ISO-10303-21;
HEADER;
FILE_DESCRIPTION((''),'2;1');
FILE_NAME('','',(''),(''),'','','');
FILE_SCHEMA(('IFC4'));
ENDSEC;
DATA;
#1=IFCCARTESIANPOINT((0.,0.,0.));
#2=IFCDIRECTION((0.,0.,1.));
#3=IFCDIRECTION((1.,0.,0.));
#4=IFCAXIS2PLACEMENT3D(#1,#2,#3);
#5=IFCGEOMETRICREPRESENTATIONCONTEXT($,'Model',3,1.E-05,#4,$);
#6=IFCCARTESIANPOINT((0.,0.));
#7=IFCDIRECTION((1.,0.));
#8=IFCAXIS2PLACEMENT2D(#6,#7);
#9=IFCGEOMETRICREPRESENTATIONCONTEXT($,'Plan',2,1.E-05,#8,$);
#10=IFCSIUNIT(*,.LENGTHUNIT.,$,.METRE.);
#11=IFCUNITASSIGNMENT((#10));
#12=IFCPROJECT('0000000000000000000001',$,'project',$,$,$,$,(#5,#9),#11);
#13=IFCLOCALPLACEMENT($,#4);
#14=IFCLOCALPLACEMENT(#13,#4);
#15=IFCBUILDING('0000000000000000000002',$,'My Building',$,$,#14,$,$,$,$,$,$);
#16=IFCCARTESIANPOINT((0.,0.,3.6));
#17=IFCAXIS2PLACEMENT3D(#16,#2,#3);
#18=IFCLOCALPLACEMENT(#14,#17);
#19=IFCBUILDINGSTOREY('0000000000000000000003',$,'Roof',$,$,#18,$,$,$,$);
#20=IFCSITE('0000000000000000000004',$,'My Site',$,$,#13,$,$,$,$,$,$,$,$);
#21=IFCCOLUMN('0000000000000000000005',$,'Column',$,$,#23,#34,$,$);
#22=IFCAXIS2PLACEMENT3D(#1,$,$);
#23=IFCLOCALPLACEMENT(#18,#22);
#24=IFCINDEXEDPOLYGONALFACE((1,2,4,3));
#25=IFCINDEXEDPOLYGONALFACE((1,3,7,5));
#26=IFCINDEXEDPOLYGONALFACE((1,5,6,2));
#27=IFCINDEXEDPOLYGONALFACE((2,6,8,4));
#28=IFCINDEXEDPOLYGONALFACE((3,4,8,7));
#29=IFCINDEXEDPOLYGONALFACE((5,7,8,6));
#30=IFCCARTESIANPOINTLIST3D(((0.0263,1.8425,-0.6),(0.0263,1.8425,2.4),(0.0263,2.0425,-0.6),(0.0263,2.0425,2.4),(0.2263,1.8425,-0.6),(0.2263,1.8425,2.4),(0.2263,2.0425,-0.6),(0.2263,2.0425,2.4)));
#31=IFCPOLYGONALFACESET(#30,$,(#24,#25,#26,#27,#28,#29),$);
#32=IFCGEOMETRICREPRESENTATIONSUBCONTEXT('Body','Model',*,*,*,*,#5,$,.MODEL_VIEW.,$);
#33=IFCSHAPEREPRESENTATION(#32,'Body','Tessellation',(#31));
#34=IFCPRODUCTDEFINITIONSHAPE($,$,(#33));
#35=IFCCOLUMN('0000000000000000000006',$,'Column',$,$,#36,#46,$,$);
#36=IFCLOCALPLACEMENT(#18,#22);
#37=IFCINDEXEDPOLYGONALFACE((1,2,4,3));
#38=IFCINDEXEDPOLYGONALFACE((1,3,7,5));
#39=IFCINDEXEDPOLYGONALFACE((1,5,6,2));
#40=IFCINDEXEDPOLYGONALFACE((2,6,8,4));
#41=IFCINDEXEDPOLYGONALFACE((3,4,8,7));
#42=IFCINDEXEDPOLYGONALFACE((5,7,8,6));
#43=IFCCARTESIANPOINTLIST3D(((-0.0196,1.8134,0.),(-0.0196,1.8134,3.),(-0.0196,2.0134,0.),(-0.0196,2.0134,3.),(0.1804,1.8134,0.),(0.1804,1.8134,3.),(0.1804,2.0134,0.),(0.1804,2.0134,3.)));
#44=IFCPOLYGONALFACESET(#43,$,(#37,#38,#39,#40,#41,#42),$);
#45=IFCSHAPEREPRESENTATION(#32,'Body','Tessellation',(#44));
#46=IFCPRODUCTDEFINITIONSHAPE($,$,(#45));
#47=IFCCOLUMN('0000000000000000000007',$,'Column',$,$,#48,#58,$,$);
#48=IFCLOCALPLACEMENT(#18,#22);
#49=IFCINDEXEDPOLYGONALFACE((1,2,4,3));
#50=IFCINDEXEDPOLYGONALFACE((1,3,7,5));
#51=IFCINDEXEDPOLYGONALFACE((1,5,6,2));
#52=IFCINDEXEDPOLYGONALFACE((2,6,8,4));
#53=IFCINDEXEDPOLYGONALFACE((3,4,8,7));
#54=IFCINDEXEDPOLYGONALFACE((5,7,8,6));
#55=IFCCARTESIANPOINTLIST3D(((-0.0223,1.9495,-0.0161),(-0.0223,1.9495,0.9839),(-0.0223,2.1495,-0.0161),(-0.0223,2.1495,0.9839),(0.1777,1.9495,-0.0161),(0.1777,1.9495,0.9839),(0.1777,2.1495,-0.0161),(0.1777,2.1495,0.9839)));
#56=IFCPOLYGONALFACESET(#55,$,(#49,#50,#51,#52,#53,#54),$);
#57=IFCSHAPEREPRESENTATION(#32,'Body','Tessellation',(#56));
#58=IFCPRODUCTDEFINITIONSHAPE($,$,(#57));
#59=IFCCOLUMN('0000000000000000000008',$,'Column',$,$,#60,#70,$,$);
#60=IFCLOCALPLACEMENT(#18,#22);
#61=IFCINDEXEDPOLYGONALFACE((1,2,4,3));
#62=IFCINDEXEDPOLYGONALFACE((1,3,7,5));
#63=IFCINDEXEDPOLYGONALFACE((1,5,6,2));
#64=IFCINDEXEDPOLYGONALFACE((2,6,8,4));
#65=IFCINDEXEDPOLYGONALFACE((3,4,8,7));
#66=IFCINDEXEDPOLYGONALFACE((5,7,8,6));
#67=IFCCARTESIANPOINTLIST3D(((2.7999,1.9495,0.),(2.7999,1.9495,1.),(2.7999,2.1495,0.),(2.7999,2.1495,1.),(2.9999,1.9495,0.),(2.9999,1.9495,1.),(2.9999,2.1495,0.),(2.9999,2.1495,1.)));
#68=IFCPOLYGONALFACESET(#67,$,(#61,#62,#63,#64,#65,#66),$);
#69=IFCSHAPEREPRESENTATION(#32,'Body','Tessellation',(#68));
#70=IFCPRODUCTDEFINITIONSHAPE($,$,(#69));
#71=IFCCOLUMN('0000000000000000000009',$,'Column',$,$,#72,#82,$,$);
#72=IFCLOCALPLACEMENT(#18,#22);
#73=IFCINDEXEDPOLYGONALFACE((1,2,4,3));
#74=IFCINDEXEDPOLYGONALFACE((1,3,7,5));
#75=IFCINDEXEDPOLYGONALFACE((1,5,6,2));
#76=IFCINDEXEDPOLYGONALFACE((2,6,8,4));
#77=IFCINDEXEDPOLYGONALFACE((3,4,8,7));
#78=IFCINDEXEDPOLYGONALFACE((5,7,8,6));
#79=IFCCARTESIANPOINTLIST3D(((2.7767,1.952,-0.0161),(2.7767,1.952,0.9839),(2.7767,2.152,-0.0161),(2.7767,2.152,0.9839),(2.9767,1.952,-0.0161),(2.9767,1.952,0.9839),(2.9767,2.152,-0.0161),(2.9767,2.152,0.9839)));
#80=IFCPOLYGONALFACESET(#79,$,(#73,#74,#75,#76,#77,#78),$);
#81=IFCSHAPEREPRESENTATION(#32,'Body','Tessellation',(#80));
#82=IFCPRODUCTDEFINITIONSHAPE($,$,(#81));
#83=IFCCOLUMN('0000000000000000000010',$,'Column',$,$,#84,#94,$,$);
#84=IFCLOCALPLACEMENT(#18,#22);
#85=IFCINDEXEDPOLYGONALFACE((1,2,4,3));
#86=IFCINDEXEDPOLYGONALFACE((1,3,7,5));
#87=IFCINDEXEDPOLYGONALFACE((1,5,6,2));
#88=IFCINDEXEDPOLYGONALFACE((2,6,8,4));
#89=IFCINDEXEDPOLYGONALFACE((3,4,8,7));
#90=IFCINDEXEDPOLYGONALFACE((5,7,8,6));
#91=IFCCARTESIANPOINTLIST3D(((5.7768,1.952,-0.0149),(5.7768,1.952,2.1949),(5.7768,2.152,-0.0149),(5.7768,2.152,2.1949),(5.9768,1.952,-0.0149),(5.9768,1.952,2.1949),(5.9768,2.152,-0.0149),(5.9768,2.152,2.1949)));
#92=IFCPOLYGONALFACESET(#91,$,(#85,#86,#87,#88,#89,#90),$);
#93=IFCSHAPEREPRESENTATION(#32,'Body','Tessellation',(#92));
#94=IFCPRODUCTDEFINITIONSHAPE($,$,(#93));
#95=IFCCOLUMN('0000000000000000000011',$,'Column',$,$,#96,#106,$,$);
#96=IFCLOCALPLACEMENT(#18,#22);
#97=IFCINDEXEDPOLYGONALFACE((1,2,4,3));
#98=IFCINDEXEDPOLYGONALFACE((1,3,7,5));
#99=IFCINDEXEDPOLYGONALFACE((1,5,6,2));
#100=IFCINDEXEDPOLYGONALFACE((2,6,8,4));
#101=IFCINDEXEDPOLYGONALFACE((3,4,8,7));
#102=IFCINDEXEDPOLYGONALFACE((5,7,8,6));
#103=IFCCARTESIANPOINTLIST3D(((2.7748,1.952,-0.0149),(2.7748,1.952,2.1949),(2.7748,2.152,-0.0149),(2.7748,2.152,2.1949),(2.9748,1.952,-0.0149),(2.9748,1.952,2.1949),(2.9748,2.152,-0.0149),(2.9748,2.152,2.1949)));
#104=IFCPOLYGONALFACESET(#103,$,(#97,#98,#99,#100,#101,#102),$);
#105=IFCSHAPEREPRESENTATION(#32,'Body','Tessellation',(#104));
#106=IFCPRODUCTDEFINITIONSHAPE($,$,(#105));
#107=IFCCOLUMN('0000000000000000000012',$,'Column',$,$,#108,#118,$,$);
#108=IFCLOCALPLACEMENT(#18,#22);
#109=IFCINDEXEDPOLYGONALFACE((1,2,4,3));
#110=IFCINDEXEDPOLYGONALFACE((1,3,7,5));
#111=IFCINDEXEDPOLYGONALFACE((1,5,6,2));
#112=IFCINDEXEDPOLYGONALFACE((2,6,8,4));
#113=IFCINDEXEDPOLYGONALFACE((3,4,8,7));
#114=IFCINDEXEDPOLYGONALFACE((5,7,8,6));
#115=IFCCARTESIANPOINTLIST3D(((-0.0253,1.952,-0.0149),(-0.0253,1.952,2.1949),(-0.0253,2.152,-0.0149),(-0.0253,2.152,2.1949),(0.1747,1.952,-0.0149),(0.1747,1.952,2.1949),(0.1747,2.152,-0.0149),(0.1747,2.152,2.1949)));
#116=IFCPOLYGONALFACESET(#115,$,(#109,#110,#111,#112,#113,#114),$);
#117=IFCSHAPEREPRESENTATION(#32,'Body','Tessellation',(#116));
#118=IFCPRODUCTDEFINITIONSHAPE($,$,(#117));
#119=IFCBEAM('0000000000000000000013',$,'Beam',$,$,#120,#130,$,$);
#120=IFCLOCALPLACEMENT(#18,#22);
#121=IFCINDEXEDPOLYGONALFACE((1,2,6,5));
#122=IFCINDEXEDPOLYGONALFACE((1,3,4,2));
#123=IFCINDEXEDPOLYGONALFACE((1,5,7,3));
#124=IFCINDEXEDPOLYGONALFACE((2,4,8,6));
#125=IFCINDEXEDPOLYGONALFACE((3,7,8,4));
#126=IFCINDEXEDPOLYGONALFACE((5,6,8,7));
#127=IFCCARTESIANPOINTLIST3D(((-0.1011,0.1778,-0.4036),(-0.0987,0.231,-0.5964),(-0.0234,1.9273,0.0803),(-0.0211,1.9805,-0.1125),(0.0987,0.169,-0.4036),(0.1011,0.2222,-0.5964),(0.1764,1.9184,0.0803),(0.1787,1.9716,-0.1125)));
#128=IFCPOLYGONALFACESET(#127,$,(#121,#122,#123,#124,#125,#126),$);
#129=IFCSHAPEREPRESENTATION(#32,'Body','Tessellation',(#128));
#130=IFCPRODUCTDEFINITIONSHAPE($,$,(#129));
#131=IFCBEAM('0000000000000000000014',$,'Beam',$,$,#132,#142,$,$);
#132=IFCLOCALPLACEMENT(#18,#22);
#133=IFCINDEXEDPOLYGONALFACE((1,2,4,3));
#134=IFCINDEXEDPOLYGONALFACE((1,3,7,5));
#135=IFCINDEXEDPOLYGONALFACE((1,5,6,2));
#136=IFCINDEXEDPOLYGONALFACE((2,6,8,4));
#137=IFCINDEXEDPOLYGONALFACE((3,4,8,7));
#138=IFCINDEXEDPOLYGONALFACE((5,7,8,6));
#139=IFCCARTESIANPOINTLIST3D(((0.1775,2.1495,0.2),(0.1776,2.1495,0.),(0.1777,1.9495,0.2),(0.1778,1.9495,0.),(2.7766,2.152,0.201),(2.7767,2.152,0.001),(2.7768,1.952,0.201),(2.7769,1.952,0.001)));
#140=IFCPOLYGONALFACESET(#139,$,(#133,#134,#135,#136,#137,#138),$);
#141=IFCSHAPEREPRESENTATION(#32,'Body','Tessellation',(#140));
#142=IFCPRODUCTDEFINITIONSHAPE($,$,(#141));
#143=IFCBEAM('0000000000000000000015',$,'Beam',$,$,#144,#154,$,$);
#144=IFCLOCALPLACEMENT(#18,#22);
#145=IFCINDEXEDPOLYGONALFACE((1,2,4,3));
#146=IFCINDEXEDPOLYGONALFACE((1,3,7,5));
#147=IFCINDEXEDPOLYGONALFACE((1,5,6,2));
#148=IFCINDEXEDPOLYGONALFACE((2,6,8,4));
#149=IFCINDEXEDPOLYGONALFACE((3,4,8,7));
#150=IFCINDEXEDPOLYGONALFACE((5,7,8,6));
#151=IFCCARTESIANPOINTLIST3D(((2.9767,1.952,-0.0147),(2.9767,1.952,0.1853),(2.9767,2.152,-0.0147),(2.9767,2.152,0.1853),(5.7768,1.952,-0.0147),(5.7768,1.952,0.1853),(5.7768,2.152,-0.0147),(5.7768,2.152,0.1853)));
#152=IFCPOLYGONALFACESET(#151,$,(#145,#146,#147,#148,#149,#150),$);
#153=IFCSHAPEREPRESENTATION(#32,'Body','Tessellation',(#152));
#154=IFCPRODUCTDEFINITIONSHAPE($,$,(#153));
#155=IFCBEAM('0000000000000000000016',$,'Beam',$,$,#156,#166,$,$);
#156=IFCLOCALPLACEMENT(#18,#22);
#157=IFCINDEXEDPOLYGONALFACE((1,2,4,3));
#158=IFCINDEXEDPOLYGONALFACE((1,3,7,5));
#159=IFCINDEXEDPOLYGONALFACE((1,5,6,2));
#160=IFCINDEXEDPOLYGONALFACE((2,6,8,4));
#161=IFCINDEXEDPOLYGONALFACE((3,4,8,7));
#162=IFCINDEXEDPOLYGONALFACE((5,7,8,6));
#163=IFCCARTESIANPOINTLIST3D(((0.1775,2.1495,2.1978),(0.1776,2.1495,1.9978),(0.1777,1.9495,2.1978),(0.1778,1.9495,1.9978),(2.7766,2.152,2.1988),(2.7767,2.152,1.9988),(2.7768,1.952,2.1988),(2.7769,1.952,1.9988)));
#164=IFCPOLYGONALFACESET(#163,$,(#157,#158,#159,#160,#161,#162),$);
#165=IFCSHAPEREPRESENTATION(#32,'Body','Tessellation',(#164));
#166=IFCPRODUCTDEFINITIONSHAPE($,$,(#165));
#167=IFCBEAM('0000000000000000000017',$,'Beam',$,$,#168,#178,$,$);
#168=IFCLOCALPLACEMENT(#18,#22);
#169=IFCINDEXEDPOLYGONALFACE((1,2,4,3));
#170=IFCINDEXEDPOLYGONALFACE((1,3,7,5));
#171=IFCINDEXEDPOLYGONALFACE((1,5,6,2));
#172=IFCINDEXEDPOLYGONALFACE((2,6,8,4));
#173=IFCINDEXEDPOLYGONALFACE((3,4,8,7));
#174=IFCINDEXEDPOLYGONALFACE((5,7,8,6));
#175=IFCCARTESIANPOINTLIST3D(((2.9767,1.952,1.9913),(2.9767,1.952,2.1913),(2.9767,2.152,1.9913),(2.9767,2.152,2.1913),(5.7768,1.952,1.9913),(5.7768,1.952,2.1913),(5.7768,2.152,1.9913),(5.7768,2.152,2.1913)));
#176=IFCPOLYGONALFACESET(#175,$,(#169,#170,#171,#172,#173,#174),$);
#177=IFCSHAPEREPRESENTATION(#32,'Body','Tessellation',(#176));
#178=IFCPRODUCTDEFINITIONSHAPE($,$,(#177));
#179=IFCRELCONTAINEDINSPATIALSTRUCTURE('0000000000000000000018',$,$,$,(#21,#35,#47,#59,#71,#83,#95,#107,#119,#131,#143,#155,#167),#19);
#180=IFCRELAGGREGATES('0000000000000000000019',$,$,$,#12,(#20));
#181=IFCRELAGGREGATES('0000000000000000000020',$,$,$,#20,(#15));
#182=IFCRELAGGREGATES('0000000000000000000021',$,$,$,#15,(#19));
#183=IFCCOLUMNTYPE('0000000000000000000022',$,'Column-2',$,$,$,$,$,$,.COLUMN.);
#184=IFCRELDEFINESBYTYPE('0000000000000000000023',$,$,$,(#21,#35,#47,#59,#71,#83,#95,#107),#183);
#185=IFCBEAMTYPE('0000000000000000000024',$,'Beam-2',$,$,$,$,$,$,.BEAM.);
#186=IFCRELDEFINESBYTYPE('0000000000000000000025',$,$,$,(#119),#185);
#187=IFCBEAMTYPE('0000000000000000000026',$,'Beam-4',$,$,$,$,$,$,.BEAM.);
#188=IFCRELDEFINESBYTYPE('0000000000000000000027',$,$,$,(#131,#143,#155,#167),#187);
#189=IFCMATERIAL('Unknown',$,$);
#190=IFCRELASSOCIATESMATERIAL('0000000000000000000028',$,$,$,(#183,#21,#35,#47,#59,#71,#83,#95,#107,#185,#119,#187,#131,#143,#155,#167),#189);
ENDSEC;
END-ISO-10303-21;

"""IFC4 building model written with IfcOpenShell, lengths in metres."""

from ifc_helpers import new_model, si_unit, frame, origin_with_axes, origin_2d_with_axis, place, context, subcontext, project, spatial, rectangle, extrude, material, material_profile, profile_set, profile_usage, type_object, element, save


model = new_model("IFC4")

# Units and contexts
model_context = context("Model", 3, precision=1e-05, world=origin_with_axes())
plan_context = context("Plan", 2, precision=1e-05, world=origin_2d_with_axis())
body_context = subcontext(model_context, "Body", "Model", "MODEL_VIEW")
ifc_project = project(units=[si_unit("LENGTHUNIT", "METRE")], contexts=[model_context, plan_context])

# Site, building, storey
site_placement = place(None, origin_with_axes())
site = spatial("IfcSite", under=ifc_project, at=site_placement, Name="My Site")
building_placement = place(site_placement, origin_with_axes())
building = spatial("IfcBuilding", under=site, at=building_placement, Name="My Building")
storey_placement = place(building_placement, frame((0.0, 0.0, 3.6), z_axis=(0.0, 0.0, 1.0), x_axis=(1.0, 0.0, 0.0)))
storey = spatial("IfcBuildingStorey", under=building, at=storey_placement, Name="Roof")

# Columns
ifc_material = material(Name="Unknown")
ifc_material_profile_1 = material_profile(ifc_material, rectangle(XDim=0.2, YDim=0.2))
ifc_profile_set_1 = profile_set([ifc_material_profile_1])
ifc_profile_usage_1 = profile_usage(ifc_profile_set_1, cardinal=5)
column_type = type_object("IfcColumnType", Name="Column-2", PredefinedType="COLUMN", material=ifc_profile_set_1)
column_1_placement = place(storey_placement, frame((0.1263, 1.9425, -0.6), z_axis=(0.0, 0.0, 1.0), x_axis=(1.0, 0.0, 0.0)))
element("IfcColumn", 1, at=column_1_placement, inside=storey, type_object=column_type, material=ifc_profile_usage_1, Name="Column", context=body_context, shape_type="SweptSolid", body=[
    extrude(rectangle(XDim=0.2, YDim=0.2), origin_with_axes(), (0.0, 0.0, 1.0), 3.0),
])
ifc_profile_usage_2 = profile_usage(ifc_profile_set_1, cardinal=5)
column_2_placement = place(storey_placement, frame((0.0804, 1.9134, 0.0), z_axis=(0.0, 0.0, 1.0), x_axis=(1.0, 0.0, 0.0)))
element("IfcColumn", 2, at=column_2_placement, inside=storey, type_object=column_type, material=ifc_profile_usage_2, Name="Column", context=body_context, shape_type="SweptSolid", body=[
    extrude(rectangle(XDim=0.2, YDim=0.2), origin_with_axes(), (0.0, 0.0, 1.0), 3.0),
])
ifc_profile_usage_3 = profile_usage(ifc_profile_set_1, cardinal=5)
column_3_placement = place(storey_placement, frame((0.0777, 2.0495, -0.0161), z_axis=(0.0, 0.0, 1.0), x_axis=(1.0, 0.0, 0.0)))
element("IfcColumn", 3, at=column_3_placement, inside=storey, type_object=column_type, material=ifc_profile_usage_3, Name="Column", context=body_context, shape_type="SweptSolid", body=[
    extrude(rectangle(XDim=0.2, YDim=0.2), origin_with_axes(), (0.0, 0.0, 1.0), 1.0),
])
ifc_profile_usage_4 = profile_usage(ifc_profile_set_1, cardinal=5)
column_4_placement = place(storey_placement, frame((2.8999, 2.0495, 0.0), z_axis=(0.0, 0.0, 1.0), x_axis=(1.0, 0.0, 0.0)))
element("IfcColumn", 4, at=column_4_placement, inside=storey, type_object=column_type, material=ifc_profile_usage_4, Name="Column", context=body_context, shape_type="SweptSolid", body=[
    extrude(rectangle(XDim=0.2, YDim=0.2), origin_with_axes(), (0.0, 0.0, 1.0), 1.0),
])
ifc_profile_usage_5 = profile_usage(ifc_profile_set_1, cardinal=5)
column_5_placement = place(storey_placement, frame((2.8767, 2.052, -0.0161), z_axis=(0.0, 0.0, 1.0), x_axis=(1.0, 0.0, 0.0)))
element("IfcColumn", 5, at=column_5_placement, inside=storey, type_object=column_type, material=ifc_profile_usage_5, Name="Column", context=body_context, shape_type="SweptSolid", body=[
    extrude(rectangle(XDim=0.2, YDim=0.2), origin_with_axes(), (0.0, 0.0, 1.0), 1.0),
])
ifc_profile_usage_6 = profile_usage(ifc_profile_set_1, cardinal=5)
column_6_placement = place(storey_placement, frame((5.8768, 2.052, -0.0149), z_axis=(0.0, 0.0, 1.0), x_axis=(1.0, 0.0, 0.0)))
element("IfcColumn", 6, at=column_6_placement, inside=storey, type_object=column_type, material=ifc_profile_usage_6, Name="Column", context=body_context, shape_type="SweptSolid", body=[
    extrude(rectangle(XDim=0.2, YDim=0.2), origin_with_axes(), (0.0, 0.0, 1.0), 2.2098),
])
ifc_profile_usage_7 = profile_usage(ifc_profile_set_1, cardinal=5)
column_7_placement = place(storey_placement, frame((2.8748, 2.052, -0.0149), z_axis=(0.0, 0.0, 1.0), x_axis=(1.0, 0.0, 0.0)))
element("IfcColumn", 7, at=column_7_placement, inside=storey, type_object=column_type, material=ifc_profile_usage_7, Name="Column", context=body_context, shape_type="SweptSolid", body=[
    extrude(rectangle(XDim=0.2, YDim=0.2), origin_with_axes(), (0.0, 0.0, 1.0), 2.2098),
])
ifc_profile_usage_8 = profile_usage(ifc_profile_set_1, cardinal=5)
column_8_placement = place(storey_placement, frame((0.0747, 2.052, -0.0149), z_axis=(0.0, 0.0, 1.0), x_axis=(1.0, 0.0, 0.0)))
element("IfcColumn", 8, at=column_8_placement, inside=storey, type_object=column_type, material=ifc_profile_usage_8, Name="Column", context=body_context, shape_type="SweptSolid", body=[
    extrude(rectangle(XDim=0.2, YDim=0.2), origin_with_axes(), (0.0, 0.0, 1.0), 2.2098),
])

# Beams
ifc_material_profile_2 = material_profile(ifc_material, rectangle(XDim=0.2, YDim=0.2))
ifc_profile_set_2 = profile_set([ifc_material_profile_2])
ifc_profile_usage_9 = profile_usage(ifc_profile_set_2, cardinal=5)
beam_type_1 = type_object("IfcBeamType", Name="Beam-2", PredefinedType="BEAM", material=ifc_profile_set_2)
beam_1_placement = place(storey_placement, frame((0.0777, 1.9495, -0.0161), z_axis=(-0.042742, -0.962929, -0.266347), x_axis=(0.999016, -0.044344, 0.0)))
element("IfcBeam", 9, at=beam_1_placement, inside=storey, type_object=beam_type_1, material=ifc_profile_usage_9, Name="Beam", context=body_context, shape_type="SweptSolid", body=[
    extrude(rectangle(XDim=0.2, YDim=0.2), origin_with_axes(), (0.0, 0.0, 1.0), 1.8168),
])
ifc_material_profile_3 = material_profile(ifc_material, rectangle(XDim=0.2, YDim=0.2))
ifc_profile_set_3 = profile_set([ifc_material_profile_3])
ifc_profile_usage_10 = profile_usage(ifc_profile_set_3, cardinal=5)
beam_type_2 = type_object("IfcBeamType", Name="Beam-4", PredefinedType="BEAM", material=ifc_profile_set_3)
beam_2_placement = place(storey_placement, frame((2.7767, 2.052, 0.101), z_axis=(-0.999999, -0.000983, -0.000394), x_axis=(0.000983, -1.0, 0.0)))
element("IfcBeam", 10, at=beam_2_placement, inside=storey, type_object=beam_type_2, material=ifc_profile_usage_10, Name="Beam", context=body_context, shape_type="SweptSolid", body=[
    extrude(rectangle(XDim=0.2, YDim=0.2), origin_with_axes(), (0.0, 0.0, 1.0), 2.5991),
])
ifc_profile_usage_11 = profile_usage(ifc_profile_set_3, cardinal=5)
beam_3_placement = place(storey_placement, frame((5.7768, 2.052, 0.0853), z_axis=(-1.0, -0.000004, 0.0), x_axis=(0.000004, -1.0, 0.0)))
element("IfcBeam", 11, at=beam_3_placement, inside=storey, type_object=beam_type_2, material=ifc_profile_usage_11, Name="Beam", context=body_context, shape_type="SweptSolid", body=[
    extrude(rectangle(XDim=0.2, YDim=0.2), origin_with_axes(), (0.0, 0.0, 1.0), 2.8),
])
ifc_profile_usage_12 = profile_usage(ifc_profile_set_3, cardinal=5)
beam_4_placement = place(storey_placement, frame((2.7767, 2.052, 2.0988), z_axis=(-0.999999, -0.000983, -0.000394), x_axis=(0.000983, -1.0, 0.0)))
element("IfcBeam", 12, at=beam_4_placement, inside=storey, type_object=beam_type_2, material=ifc_profile_usage_12, Name="Beam", context=body_context, shape_type="SweptSolid", body=[
    extrude(rectangle(XDim=0.2, YDim=0.2), origin_with_axes(), (0.0, 0.0, 1.0), 2.5991),
])
ifc_profile_usage_13 = profile_usage(ifc_profile_set_3, cardinal=5)
beam_5_placement = place(storey_placement, frame((5.7768, 2.052, 2.0913), z_axis=(-1.0, -0.000004, 0.0), x_axis=(0.000004, -1.0, 0.0)))
element("IfcBeam", 13, at=beam_5_placement, inside=storey, type_object=beam_type_2, material=ifc_profile_usage_13, Name="Beam", context=body_context, shape_type="SweptSolid", body=[
    extrude(rectangle(XDim=0.2, YDim=0.2), origin_with_axes(), (0.0, 0.0, 1.0), 2.8),
])

save(model, "model.ifc")
